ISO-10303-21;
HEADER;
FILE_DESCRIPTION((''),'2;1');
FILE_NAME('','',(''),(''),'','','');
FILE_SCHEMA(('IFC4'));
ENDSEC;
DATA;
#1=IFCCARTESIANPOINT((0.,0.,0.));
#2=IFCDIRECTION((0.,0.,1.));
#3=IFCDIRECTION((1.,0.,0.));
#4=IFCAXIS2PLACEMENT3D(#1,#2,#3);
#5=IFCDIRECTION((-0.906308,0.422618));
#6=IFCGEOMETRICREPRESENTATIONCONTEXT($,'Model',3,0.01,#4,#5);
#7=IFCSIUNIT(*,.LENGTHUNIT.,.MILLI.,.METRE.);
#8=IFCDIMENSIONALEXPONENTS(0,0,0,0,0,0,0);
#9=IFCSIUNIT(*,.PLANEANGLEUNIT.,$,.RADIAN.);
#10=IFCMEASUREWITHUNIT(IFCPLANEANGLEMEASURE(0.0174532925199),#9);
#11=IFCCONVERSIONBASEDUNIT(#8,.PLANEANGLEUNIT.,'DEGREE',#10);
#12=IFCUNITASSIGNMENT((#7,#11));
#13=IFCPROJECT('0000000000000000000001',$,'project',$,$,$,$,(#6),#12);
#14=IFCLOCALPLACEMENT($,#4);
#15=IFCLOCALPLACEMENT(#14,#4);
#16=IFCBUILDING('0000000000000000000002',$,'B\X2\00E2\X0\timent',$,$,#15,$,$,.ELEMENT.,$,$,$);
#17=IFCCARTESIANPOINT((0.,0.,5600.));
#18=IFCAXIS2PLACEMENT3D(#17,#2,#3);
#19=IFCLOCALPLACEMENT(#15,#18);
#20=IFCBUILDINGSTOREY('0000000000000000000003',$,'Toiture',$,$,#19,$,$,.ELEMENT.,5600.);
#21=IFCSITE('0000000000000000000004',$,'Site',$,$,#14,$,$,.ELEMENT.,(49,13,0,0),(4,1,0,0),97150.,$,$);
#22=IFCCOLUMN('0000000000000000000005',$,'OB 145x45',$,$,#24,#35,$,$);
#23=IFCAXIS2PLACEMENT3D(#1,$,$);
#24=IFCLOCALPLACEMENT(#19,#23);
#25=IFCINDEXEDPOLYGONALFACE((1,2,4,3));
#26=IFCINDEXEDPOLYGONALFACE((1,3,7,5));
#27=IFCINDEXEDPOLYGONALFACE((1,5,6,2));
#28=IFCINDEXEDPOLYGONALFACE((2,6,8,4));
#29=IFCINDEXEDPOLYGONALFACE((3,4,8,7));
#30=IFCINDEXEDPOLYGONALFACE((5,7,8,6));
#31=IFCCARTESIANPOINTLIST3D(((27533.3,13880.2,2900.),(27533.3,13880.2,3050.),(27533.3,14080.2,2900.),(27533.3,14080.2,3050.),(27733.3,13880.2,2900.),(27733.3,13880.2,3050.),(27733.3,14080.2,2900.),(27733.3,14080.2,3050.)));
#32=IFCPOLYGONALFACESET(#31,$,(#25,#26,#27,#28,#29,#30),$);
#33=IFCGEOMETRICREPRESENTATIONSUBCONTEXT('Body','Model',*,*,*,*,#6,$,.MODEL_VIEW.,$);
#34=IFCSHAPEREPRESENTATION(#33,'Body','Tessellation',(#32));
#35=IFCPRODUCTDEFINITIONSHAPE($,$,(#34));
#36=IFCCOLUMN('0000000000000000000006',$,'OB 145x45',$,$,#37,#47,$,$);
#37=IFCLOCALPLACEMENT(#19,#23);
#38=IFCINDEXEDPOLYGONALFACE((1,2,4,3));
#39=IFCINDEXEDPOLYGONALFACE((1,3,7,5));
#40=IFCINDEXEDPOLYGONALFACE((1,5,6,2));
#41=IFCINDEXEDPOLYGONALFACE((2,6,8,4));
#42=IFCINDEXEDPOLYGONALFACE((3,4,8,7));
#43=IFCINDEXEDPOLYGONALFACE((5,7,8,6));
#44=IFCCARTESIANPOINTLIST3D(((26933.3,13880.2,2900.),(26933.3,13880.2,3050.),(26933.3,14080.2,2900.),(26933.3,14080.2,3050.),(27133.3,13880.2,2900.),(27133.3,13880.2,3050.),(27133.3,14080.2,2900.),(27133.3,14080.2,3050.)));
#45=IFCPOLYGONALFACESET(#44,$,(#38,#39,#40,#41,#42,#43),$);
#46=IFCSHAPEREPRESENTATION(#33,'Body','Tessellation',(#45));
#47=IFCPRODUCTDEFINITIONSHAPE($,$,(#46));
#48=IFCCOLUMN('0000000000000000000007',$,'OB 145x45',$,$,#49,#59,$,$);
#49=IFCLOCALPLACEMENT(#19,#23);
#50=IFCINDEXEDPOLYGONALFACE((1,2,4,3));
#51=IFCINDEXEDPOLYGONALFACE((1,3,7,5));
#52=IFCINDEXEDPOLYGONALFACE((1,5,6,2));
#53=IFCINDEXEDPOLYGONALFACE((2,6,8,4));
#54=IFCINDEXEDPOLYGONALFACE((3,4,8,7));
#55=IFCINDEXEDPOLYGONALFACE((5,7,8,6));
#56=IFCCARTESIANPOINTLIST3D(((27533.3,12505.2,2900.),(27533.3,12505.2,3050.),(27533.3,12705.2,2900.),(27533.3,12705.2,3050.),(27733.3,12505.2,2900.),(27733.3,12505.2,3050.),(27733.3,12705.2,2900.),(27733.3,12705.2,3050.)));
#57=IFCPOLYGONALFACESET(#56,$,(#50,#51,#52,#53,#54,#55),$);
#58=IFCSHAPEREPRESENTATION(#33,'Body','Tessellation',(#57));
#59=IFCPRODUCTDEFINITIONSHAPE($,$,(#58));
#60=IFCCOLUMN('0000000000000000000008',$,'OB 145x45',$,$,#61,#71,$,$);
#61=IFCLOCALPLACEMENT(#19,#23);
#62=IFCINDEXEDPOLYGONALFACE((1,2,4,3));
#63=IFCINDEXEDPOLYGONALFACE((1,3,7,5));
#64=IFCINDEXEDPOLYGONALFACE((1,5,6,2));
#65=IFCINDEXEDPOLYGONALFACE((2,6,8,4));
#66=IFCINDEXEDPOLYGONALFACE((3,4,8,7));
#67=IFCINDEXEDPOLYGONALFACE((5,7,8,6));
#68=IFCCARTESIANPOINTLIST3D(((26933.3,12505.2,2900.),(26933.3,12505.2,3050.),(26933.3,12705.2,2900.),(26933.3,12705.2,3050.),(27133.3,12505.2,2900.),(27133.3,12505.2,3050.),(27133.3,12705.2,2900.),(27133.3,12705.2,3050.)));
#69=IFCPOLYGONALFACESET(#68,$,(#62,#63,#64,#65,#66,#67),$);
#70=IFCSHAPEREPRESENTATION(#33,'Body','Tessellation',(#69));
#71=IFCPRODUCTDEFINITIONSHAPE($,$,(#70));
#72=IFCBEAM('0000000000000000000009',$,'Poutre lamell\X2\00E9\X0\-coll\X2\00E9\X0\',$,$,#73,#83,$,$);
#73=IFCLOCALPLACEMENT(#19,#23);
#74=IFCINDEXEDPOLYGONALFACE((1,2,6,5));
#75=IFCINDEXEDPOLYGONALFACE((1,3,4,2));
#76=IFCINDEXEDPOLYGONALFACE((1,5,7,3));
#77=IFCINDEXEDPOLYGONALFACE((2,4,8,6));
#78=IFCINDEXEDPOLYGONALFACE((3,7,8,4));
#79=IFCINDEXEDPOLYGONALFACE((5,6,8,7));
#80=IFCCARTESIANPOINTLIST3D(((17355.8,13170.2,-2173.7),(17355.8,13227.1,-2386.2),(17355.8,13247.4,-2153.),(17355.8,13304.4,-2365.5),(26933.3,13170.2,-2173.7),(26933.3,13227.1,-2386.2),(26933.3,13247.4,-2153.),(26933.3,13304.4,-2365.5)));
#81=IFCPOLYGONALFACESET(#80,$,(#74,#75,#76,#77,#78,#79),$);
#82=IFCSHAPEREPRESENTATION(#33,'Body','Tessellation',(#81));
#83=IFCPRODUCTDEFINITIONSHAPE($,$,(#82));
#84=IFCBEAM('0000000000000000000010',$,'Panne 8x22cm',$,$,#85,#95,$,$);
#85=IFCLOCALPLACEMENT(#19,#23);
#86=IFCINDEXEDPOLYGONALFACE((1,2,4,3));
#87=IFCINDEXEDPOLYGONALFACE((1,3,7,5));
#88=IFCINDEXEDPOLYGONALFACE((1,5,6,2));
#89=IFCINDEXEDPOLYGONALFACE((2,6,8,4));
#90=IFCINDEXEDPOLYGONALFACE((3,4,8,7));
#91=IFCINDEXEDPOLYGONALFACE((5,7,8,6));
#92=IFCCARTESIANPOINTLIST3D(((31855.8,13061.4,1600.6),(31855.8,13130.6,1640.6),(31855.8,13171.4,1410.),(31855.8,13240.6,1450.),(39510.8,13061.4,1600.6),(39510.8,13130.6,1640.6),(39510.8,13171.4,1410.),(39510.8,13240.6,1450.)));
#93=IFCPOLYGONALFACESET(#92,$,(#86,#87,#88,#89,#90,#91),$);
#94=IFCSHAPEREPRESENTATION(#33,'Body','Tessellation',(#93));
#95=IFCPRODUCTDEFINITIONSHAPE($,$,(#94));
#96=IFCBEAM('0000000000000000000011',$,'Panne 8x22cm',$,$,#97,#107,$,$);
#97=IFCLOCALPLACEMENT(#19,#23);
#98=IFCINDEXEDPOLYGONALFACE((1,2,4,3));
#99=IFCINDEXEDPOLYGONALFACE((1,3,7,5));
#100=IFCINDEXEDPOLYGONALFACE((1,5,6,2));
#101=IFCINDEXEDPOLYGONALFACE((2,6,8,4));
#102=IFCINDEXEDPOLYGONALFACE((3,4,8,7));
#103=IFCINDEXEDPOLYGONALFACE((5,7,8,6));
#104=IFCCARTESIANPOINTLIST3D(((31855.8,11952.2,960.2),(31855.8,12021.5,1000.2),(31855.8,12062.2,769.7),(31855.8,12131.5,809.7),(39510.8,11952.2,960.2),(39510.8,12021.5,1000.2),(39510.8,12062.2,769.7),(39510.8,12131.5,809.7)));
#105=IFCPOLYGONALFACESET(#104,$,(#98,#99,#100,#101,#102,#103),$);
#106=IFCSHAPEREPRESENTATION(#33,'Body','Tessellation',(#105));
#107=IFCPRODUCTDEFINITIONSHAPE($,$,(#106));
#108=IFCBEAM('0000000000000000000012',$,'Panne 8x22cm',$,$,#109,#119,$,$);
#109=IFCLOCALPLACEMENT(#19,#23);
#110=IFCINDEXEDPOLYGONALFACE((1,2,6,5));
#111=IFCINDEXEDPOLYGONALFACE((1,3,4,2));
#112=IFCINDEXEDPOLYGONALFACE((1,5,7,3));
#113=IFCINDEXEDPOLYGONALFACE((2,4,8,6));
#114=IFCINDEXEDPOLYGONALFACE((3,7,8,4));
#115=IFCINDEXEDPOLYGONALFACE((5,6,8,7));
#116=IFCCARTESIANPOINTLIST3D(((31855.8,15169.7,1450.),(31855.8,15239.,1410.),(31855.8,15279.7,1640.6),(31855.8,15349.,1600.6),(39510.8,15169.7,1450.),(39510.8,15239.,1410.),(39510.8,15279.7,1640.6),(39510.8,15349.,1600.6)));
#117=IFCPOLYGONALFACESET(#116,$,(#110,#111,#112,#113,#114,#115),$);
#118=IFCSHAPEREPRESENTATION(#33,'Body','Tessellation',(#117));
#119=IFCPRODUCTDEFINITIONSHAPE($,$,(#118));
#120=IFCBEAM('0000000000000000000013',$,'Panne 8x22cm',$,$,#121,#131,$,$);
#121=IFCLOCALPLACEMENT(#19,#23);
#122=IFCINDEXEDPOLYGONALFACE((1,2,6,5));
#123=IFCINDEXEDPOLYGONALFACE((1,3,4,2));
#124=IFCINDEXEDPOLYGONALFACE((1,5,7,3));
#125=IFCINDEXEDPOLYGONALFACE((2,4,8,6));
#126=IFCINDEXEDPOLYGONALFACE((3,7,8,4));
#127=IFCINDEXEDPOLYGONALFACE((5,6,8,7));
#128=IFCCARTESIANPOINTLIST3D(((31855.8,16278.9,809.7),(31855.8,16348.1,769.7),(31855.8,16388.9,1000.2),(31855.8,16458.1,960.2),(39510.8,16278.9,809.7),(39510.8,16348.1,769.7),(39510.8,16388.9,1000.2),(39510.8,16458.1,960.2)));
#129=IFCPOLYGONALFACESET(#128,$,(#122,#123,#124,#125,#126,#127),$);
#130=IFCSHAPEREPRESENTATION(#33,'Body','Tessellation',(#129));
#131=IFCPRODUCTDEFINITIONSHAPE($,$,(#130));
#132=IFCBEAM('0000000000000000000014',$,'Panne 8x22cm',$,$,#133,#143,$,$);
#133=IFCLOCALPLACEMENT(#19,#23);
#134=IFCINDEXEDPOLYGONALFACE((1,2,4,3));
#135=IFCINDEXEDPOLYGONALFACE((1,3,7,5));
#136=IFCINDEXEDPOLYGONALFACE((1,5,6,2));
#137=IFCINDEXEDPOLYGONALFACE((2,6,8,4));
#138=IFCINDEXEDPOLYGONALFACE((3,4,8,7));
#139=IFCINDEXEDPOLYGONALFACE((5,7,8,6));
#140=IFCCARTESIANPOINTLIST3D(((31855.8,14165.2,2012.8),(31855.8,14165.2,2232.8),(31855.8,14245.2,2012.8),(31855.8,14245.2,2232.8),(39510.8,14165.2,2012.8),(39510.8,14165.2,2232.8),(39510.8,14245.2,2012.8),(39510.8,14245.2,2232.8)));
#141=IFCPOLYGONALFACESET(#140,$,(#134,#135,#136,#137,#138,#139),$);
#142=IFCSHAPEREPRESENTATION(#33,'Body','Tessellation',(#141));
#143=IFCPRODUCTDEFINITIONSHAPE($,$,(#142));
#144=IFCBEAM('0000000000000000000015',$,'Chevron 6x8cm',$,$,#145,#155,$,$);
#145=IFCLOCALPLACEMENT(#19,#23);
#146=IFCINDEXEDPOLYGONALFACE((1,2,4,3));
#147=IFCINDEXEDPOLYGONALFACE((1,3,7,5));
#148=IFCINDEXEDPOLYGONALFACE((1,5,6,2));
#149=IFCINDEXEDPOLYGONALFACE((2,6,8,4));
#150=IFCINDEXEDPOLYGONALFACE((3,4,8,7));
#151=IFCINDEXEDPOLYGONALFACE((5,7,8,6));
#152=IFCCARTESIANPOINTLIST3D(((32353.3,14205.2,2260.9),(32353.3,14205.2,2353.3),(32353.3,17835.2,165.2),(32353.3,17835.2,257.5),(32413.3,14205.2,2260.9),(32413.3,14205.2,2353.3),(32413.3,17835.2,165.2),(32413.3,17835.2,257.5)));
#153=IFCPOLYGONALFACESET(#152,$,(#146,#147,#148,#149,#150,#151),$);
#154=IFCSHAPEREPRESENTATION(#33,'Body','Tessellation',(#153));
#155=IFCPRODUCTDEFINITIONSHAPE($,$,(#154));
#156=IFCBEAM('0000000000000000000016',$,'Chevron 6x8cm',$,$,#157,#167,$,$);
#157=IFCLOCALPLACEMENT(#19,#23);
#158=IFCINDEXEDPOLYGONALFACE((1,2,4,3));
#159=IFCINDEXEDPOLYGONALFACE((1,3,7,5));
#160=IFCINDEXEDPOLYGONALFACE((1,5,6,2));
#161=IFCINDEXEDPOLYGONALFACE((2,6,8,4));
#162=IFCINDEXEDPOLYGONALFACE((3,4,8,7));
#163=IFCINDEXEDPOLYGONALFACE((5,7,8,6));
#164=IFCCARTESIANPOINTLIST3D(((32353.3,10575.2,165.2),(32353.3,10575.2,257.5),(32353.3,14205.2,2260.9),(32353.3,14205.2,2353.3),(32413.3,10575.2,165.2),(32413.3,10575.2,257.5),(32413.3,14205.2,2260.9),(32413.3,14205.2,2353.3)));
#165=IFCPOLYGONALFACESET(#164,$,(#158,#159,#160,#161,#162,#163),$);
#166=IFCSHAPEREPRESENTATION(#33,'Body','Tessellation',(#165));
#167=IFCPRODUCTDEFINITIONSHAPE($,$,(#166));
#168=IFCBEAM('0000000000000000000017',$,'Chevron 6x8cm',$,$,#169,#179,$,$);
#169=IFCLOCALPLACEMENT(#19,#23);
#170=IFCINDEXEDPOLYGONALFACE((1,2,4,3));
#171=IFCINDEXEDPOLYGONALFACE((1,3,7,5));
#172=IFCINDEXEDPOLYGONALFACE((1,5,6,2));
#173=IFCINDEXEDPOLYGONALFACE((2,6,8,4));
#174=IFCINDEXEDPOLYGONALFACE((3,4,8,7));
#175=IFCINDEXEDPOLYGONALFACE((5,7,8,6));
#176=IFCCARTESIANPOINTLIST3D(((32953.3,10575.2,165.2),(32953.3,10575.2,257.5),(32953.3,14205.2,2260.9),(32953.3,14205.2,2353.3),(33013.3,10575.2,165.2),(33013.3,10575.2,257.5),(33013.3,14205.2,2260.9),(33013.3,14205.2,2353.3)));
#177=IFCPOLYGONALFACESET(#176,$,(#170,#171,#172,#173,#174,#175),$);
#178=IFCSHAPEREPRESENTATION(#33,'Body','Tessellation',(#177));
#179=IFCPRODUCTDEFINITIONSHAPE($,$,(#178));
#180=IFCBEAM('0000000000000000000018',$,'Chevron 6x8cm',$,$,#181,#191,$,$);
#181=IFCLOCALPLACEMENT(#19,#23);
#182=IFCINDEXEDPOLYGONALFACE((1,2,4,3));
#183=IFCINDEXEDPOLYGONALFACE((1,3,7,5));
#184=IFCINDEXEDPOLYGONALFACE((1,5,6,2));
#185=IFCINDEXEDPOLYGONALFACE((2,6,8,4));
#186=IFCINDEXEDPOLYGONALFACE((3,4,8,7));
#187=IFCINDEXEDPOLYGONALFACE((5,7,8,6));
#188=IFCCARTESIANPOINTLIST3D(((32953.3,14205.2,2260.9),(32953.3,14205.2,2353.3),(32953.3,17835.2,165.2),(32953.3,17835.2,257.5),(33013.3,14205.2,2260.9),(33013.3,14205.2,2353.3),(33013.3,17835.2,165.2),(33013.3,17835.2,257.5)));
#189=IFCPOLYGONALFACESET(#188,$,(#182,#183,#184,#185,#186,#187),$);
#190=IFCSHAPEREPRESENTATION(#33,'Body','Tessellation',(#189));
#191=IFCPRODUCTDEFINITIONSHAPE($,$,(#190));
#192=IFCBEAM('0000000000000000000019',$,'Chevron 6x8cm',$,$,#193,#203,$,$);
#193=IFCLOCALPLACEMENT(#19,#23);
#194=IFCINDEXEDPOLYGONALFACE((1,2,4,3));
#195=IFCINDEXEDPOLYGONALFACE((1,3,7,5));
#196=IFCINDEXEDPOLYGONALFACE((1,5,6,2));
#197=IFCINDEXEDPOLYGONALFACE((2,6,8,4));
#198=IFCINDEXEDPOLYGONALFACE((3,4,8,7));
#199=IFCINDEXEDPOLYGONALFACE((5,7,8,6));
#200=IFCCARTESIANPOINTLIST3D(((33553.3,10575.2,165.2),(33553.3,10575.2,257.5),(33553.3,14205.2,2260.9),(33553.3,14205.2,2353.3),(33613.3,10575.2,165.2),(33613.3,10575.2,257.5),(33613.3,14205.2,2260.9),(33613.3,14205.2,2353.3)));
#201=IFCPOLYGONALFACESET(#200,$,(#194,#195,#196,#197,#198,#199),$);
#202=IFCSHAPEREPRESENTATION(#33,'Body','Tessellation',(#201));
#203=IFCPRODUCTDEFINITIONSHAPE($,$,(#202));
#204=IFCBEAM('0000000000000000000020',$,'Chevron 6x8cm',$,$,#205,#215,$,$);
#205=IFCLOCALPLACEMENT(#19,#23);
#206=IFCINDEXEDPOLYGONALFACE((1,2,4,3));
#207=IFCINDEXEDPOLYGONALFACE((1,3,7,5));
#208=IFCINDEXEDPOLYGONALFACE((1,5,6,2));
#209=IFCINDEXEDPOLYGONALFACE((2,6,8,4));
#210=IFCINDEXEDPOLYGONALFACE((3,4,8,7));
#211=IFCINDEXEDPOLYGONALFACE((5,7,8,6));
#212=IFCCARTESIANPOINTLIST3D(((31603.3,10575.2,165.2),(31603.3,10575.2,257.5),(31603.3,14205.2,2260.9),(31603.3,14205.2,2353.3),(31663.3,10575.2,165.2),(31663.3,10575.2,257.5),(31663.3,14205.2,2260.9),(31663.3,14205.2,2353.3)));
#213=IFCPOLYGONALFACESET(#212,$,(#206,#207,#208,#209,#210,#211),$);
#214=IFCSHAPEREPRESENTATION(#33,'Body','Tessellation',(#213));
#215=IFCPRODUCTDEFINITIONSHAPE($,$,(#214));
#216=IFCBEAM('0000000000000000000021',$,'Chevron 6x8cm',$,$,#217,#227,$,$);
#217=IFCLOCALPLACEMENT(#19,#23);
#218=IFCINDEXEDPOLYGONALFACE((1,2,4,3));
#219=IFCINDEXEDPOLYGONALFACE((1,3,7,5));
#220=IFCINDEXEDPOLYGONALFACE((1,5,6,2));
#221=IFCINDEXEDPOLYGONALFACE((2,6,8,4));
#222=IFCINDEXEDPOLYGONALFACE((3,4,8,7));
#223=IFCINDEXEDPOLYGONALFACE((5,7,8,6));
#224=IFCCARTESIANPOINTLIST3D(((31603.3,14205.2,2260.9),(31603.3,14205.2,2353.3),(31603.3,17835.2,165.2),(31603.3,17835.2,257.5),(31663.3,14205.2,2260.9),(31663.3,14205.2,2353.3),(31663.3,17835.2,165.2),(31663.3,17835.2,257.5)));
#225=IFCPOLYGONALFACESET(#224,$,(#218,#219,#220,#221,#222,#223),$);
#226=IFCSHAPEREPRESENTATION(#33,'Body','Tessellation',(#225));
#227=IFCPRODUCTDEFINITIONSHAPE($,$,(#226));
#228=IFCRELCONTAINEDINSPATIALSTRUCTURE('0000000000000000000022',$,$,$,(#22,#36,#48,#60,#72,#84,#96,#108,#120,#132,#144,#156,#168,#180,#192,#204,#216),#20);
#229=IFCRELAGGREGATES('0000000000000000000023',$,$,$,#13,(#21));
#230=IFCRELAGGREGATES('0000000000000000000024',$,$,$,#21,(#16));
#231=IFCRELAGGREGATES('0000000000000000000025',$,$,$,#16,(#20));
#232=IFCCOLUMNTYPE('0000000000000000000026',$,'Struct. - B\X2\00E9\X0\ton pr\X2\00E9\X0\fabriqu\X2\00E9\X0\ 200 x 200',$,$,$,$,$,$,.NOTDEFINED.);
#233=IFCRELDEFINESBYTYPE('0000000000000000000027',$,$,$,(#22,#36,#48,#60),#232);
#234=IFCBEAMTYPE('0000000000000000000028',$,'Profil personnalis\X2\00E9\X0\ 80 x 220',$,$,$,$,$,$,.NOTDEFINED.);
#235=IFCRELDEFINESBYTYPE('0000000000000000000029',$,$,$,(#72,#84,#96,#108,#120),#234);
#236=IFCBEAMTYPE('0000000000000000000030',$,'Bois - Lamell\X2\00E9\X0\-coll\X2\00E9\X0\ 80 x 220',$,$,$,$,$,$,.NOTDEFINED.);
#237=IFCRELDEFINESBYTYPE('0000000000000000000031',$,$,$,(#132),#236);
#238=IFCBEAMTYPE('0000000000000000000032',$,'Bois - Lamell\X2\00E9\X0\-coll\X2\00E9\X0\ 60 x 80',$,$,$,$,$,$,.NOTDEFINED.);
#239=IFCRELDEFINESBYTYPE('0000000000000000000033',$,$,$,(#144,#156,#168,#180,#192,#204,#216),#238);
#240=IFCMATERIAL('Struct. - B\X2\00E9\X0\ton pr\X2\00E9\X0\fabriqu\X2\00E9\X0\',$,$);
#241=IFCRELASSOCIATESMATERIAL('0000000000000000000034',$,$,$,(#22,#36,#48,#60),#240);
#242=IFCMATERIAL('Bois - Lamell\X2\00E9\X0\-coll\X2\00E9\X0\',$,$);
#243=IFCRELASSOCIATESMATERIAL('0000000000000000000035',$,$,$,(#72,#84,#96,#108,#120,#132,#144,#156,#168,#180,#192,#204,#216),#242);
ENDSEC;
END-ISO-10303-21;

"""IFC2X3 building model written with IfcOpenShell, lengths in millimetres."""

from ifc_helpers import new_model, entity, si_unit, converted_unit, direction, frame, frame_2d, origin_with_axes, origin_2d_with_axis, place, context, subcontext, project, spatial, polyline, rectangle, outline, extrude, clip, halfspace, material, type_object, element, save


model = new_model("IFC2X3")

# Units and contexts
model_context = context("Model", 3, precision=0.01, world=origin_with_axes(), true_north=direction((-0.906308, 0.422618)))
body_context = subcontext(model_context, "Body", "Model", "MODEL_VIEW")
ifc_project = project(units=[si_unit("LENGTHUNIT", "METRE", prefix="MILLI"), converted_unit("PLANEANGLEUNIT", "DEGREE", entity("IfcPlaneAngleMeasure", 0.0174532925199), si_unit("PLANEANGLEUNIT", "RADIAN"), dimensions=[0, 0, 0, 0, 0, 0, 0])], contexts=[model_context])

# Site, building, storey
site_placement = place(None, origin_with_axes())
site = spatial("IfcSite", under=ifc_project, at=site_placement, Name="Site", CompositionType="ELEMENT", RefLatitude=(49, 13, 0, 0), RefLongitude=(4, 1, 0, 0), RefElevation=97150.0)
building_placement = place(site_placement, origin_with_axes())
building = spatial("IfcBuilding", under=site, at=building_placement, Name="Bâtiment", CompositionType="ELEMENT")
storey_placement = place(building_placement, frame((0.0, 0.0, 5600.0), z_axis=(0.0, 0.0, 1.0), x_axis=(1.0, 0.0, 0.0)))
storey = spatial("IfcBuildingStorey", under=building, at=storey_placement, Name="Toiture", CompositionType="ELEMENT", Elevation=5600.0)

# Columns
ifc_material_1 = material(Name="Struct. - Béton préfabriqué")
column_type = type_object("IfcColumnType", Name="Struct. - Béton préfabriqué 200 x 200", PredefinedType="NOTDEFINED")
for number, where, z_axis, x_axis, name in (
    (1, (27633.3, 13980.2, 2900.0), (0.0, 0.0, 1.0), (1.0, 0.0, 0.0), "OB 145x45"),
    (2, (27033.3, 13980.2, 2900.0), (0.0, 0.0, 1.0), (1.0, 0.0, 0.0), "OB 145x45"),
    (3, (27633.3, 12605.2, 2900.0), (0.0, 0.0, 1.0), (1.0, 0.0, 0.0), "OB 145x45"),
    (4, (27033.3, 12605.2, 2900.0), (0.0, 0.0, 1.0), (1.0, 0.0, 0.0), "OB 145x45"),
):
    element("IfcColumn", number, at=place(storey_placement, frame(where, z_axis=z_axis, x_axis=x_axis)), inside=storey, type_object=column_type, material=ifc_material_1, Name=name, context=body_context, shape_type="SweptSolid", body=[
        extrude(rectangle(XDim=200.0, YDim=200.0, at=origin_2d_with_axis()), origin_with_axes(), (0.0, 0.0, 1.0), 150.0),
    ])

# Beams
ifc_material_2 = material(Name="Bois - Lamellé-collé")
beam_type_1 = type_object("IfcBeamType", Name="Profil personnalisé 80 x 220", PredefinedType="NOTDEFINED")
beam_1_placement = place(storey_placement, frame((17355.8, 13208.8, -2163.3), z_axis=(0.0, 0.0, 1.0), x_axis=(0.0, -1.0, 0.0)))
element("IfcBeam", 5, at=beam_1_placement, inside=storey, type_object=beam_type_1, material=ifc_material_2, Name="Poutre lamellé-collé", context=body_context, shape_type="SweptSolid", body=[
    extrude(outline(polyline([(-40.0, -220.0), (40.0, -220.0), (40.0, 0.0), (-40.0, 0.0), (-40.0, -220.0)])), frame((0.0, 9577.5, 0.0), z_axis=(0.0, 1.0, 0.0), x_axis=(-0.965926, 0.0, 0.258819)), (0.0, 0.0, -1.0), 9577.5),
])
for number, where, z_axis, x_axis, name in (
    (6, (31855.8, 13096.0, 1620.6), (0.0, 0.0, 1.0), (0.0, -1.0, 0.0), "Panne 8x22cm"),
    (7, (31855.8, 11986.8, 980.2), (0.0, 0.0, 1.0), (0.0, -1.0, 0.0), "Panne 8x22cm"),
):
    element("IfcBeam", number, at=place(storey_placement, frame(where, z_axis=z_axis, x_axis=x_axis)), inside=storey, type_object=beam_type_1, material=ifc_material_2, Name=name, context=body_context, shape_type="SweptSolid", body=[
        extrude(outline(polyline([(-40.0, -220.0), (40.0, -220.0), (40.0, 0.0), (-40.0, 0.0), (-40.0, -220.0)])), frame((0.0, 7655.0, 0.0), z_axis=(0.0, -1.0, 0.0), x_axis=(0.866025, 0.0, -0.5)), (0.0, 0.0, 1.0), 7655.0),
    ])
for number, where, z_axis, x_axis, name in (
    (8, (31855.8, 15314.3, 1620.6), (0.0, 0.0, 1.0), (0.0, -1.0, 0.0), "Panne 8x22cm"),
    (9, (31855.8, 16423.5, 980.2), (0.0, 0.0, 1.0), (0.0, -1.0, 0.0), "Panne 8x22cm"),
):
    element("IfcBeam", number, at=place(storey_placement, frame(where, z_axis=z_axis, x_axis=x_axis)), inside=storey, type_object=beam_type_1, material=ifc_material_2, Name=name, context=body_context, shape_type="SweptSolid", body=[
        extrude(outline(polyline([(-40.0, -220.0), (40.0, -220.0), (40.0, 0.0), (-40.0, 0.0), (-40.0, -220.0)])), frame((0.0, 7655.0, 0.0), z_axis=(0.0, 1.0, 0.0), x_axis=(-0.866025, 0.0, -0.5)), (0.0, 0.0, -1.0), 7655.0),
    ])
beam_type_2 = type_object("IfcBeamType", Name="Bois - Lamellé-collé 80 x 220", PredefinedType="NOTDEFINED")
beam_2_placement = place(storey_placement, frame((31855.8, 14205.2, 2232.8), z_axis=(0.0, 0.0, 1.0), x_axis=(0.0, -1.0, 0.0)))
element("IfcBeam", 10, at=beam_2_placement, inside=storey, type_object=beam_type_2, material=ifc_material_2, Name="Panne 8x22cm", context=body_context, shape_type="SweptSolid", body=[
    extrude(rectangle(XDim=220.0, YDim=80.0, at=frame_2d((-110.0, 0.0), x_axis=(1.0, 0.0))), frame((0.0, 0.0, 0.0), z_axis=(0.0, 1.0, 0.0), x_axis=(0.0, 0.0, 1.0)), (0.0, 0.0, 1.0), 7655.0),
])
beam_type_3 = type_object("IfcBeamType", Name="Bois - Lamellé-collé 60 x 80", PredefinedType="NOTDEFINED")
for number, where, z_axis, x_axis, name in (
    (11, (32383.3, 17835.2, 257.5), (0.0, 0.0, 1.0), (-1.0, 0.0, 0.0), "Chevron 6x8cm"),
    (12, (32383.3, 10575.2, 257.5), (0.0, 0.0, 1.0), (1.0, 0.0, 0.0), "Chevron 6x8cm"),
    (13, (32983.3, 10575.2, 257.5), (0.0, 0.0, 1.0), (1.0, 0.0, 0.0), "Chevron 6x8cm"),
    (14, (32983.3, 17835.2, 257.5), (0.0, 0.0, 1.0), (-1.0, 0.0, 0.0), "Chevron 6x8cm"),
    (15, (33583.3, 10575.2, 257.5), (0.0, 0.0, 1.0), (1.0, 0.0, 0.0), "Chevron 6x8cm"),
    (16, (31633.3, 10575.2, 257.5), (0.0, 0.0, 1.0), (1.0, 0.0, 0.0), "Chevron 6x8cm"),
    (17, (31633.3, 17835.2, 257.5), (0.0, 0.0, 1.0), (-1.0, 0.0, 0.0), "Chevron 6x8cm"),
):
    element("IfcBeam", number, at=place(storey_placement, frame(where, z_axis=z_axis, x_axis=x_axis)), inside=storey, type_object=beam_type_3, material=ifc_material_2, Name=name, context=body_context, shape_type="Clipping", body=[
        clip(clip(extrude(rectangle(XDim=80.0, YDim=60.0, at=frame_2d((-40.0, 0.0), x_axis=(1.0, 0.0))), frame((0.0, -56.6, -32.7), z_axis=(0.0, 0.866025, 0.5), x_axis=(0.0, -0.5, 0.866025)), (0.0, 0.0, 1.0), 4322.2), halfspace(frame((0.0, 0.0, 0.0), z_axis=(0.0, 1.0, 0.0), x_axis=(0.0, 0.0, 1.0)), True)), halfspace(frame((0.0, 3630.0, 0.0), z_axis=(0.0, -1.0, 0.0), x_axis=(0.0, 0.0, -1.0)), True)),
    ])

save(model, "model.ifc")
